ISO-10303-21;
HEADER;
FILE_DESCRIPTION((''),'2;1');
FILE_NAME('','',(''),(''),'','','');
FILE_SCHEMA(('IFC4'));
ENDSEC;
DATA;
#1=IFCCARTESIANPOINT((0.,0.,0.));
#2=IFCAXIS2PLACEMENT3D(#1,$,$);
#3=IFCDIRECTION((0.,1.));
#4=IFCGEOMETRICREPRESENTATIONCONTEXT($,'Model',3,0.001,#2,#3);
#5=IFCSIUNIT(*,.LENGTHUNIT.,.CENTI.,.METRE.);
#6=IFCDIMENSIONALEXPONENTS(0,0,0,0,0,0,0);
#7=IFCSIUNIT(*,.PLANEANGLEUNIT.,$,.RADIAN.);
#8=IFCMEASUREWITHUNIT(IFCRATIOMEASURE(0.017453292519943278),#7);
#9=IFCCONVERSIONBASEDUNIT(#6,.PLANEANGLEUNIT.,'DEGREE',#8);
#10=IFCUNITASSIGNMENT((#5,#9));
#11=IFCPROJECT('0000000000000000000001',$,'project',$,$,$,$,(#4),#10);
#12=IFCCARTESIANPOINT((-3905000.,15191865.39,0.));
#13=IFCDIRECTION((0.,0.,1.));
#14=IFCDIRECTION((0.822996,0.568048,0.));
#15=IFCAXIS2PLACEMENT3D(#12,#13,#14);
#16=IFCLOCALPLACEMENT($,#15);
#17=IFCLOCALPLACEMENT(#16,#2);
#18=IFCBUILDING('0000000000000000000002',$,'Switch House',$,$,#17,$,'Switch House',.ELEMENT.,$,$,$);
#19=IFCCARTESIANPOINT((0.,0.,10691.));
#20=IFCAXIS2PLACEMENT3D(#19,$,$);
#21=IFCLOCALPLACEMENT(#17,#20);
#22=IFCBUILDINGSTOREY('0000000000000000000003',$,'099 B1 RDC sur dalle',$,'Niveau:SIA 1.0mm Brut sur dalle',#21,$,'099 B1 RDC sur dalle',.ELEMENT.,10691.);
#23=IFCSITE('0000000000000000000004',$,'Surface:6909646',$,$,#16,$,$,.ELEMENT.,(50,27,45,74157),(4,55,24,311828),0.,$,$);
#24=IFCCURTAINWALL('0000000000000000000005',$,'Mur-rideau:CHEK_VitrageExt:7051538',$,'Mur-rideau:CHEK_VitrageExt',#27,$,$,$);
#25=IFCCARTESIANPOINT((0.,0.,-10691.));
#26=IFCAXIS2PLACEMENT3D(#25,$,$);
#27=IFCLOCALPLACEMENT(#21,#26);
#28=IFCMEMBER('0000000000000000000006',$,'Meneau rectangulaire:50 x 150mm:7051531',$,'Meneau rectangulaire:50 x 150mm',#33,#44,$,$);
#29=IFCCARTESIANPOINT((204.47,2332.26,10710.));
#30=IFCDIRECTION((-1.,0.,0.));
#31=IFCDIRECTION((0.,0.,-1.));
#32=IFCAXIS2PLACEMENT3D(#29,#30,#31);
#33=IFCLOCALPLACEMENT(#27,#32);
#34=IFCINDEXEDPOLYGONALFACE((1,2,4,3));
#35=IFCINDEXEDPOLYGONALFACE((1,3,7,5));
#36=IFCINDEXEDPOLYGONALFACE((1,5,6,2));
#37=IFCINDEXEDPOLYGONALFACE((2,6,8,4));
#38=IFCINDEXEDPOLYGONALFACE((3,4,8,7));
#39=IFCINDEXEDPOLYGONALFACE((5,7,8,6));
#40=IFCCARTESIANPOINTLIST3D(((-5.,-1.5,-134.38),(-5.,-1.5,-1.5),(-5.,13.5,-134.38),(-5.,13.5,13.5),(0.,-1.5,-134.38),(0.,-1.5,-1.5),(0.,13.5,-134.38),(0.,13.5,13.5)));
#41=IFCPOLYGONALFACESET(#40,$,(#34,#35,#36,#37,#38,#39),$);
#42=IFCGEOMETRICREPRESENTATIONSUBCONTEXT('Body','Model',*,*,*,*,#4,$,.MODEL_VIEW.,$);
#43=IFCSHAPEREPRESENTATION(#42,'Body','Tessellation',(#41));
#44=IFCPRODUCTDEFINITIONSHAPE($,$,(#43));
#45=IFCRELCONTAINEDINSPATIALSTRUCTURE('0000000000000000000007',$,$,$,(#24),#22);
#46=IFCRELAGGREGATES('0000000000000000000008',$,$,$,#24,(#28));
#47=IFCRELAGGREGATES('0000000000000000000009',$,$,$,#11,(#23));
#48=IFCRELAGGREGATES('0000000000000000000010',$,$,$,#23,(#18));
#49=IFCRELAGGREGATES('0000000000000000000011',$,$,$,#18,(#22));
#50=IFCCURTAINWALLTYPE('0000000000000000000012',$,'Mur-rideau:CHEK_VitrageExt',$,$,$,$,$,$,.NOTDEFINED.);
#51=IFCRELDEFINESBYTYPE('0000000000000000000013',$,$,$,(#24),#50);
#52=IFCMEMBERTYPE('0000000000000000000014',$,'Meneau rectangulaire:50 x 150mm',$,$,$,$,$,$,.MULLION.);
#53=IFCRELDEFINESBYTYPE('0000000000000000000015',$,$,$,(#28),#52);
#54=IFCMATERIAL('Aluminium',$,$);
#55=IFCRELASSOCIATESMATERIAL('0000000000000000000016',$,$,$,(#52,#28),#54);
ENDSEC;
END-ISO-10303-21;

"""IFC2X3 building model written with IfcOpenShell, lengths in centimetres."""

from ifc_helpers import new_model, entity, si_unit, converted_unit, direction, frame, origin, origin_2d_with_axis, place, context, subcontext, project, spatial, rectangle, extrude, clip, halfspace, source, transform, mapped, material, type_object, type_shapes, element, aggregate, save


model = new_model("IFC2X3")

# Units and contexts
model_context = context("Model", 3, precision=0.001, world=origin(), true_north=direction((0.0, 1.0)))
body_context = subcontext(model_context, "Body", "Model", "MODEL_VIEW")
ifc_project = project(units=[si_unit("LENGTHUNIT", "METRE", prefix="CENTI"), converted_unit("PLANEANGLEUNIT", "DEGREE", entity("IfcRatioMeasure", 0.017453292519943278), si_unit("PLANEANGLEUNIT", "RADIAN"), dimensions=[0, 0, 0, 0, 0, 0, 0])], contexts=[model_context])

# Site, building, storey
site_placement = place(None, frame((-3905000.0, 15191865.39, 0.0), z_axis=(0.0, 0.0, 1.0), x_axis=(0.822996, 0.568048, 0.0)))
site = spatial("IfcSite", under=ifc_project, at=site_placement, Name="Surface:6909646", CompositionType="ELEMENT", RefLatitude=(50, 27, 45, 74157), RefLongitude=(4, 55, 24, 311828), RefElevation=0.0)
building_placement = place(site_placement, origin())
building = spatial("IfcBuilding", under=site, at=building_placement, Name="Switch House", LongName="Switch House", CompositionType="ELEMENT")
storey_placement = place(building_placement, frame((0.0, 0.0, 10691.0)))
storey = spatial("IfcBuildingStorey", under=building, at=storey_placement, Name="099 B1 RDC sur dalle", ObjectType="Niveau:SIA 1.0mm Brut sur dalle", LongName="099 B1 RDC sur dalle", CompositionType="ELEMENT", Elevation=10691.0)

# Shared definitions
curtain_wall_type = type_object("IfcCurtainWallType", Name="Mur-rideau:CHEK_VitrageExt", PredefinedType="NOTDEFINED")
ifc_material_1 = material(Name="Aluminium")

# Curtain wall
curtain_wall_1_placement = place(storey_placement, frame((0.0, 0.0, -10691.0)))
curtain_wall_1 = element("IfcCurtainWall", 1, at=curtain_wall_1_placement, inside=storey, type_object=curtain_wall_type, Name="Mur-rideau:CHEK_VitrageExt:7051538", ObjectType="Mur-rideau:CHEK_VitrageExt")

# Member
member_type_1 = type_object("IfcMemberType", Name="Meneau rectangulaire:50 x 150mm", PredefinedType="MULLION", material=ifc_material_1)
shared_shape_1 = source(origin(), body_context, "Body", "SweptSolid", [
    clip(extrude(rectangle(XDim=15.0, YDim=5.0, at=origin_2d_with_axis()), frame((-2.5, 6.0, -134.38), z_axis=(0.0, 0.0, 1.0), x_axis=(0.0, -1.0, 0.0)), (0.0, 0.0, 1.0), 147.88), halfspace(frame((30.48, 0.0, 0.0), z_axis=(0.0, -0.707107, 0.707107), x_axis=(0.0, -0.707107, -0.707107)), False)),
])
type_shapes(member_type_1, [shared_shape_1])
member_1_placement = place(curtain_wall_1_placement, frame((204.47, 2332.26, 10710.0), z_axis=(-1.0, 0.0, 0.0), x_axis=(0.0, 0.0, -1.0)))
member_1 = element("IfcMember", 2, at=member_1_placement, type_object=member_type_1, material=ifc_material_1, Name="Meneau rectangulaire:50 x 150mm:7051531", ObjectType="Meneau rectangulaire:50 x 150mm", context=body_context, shape_type="MappedRepresentation", body=[
    mapped(shared_shape_1, transform((0.0, 0.0, 0.0), scale=1.0)),
])

aggregate(curtain_wall_1, [member_1])

save(model, "model.ifc")
